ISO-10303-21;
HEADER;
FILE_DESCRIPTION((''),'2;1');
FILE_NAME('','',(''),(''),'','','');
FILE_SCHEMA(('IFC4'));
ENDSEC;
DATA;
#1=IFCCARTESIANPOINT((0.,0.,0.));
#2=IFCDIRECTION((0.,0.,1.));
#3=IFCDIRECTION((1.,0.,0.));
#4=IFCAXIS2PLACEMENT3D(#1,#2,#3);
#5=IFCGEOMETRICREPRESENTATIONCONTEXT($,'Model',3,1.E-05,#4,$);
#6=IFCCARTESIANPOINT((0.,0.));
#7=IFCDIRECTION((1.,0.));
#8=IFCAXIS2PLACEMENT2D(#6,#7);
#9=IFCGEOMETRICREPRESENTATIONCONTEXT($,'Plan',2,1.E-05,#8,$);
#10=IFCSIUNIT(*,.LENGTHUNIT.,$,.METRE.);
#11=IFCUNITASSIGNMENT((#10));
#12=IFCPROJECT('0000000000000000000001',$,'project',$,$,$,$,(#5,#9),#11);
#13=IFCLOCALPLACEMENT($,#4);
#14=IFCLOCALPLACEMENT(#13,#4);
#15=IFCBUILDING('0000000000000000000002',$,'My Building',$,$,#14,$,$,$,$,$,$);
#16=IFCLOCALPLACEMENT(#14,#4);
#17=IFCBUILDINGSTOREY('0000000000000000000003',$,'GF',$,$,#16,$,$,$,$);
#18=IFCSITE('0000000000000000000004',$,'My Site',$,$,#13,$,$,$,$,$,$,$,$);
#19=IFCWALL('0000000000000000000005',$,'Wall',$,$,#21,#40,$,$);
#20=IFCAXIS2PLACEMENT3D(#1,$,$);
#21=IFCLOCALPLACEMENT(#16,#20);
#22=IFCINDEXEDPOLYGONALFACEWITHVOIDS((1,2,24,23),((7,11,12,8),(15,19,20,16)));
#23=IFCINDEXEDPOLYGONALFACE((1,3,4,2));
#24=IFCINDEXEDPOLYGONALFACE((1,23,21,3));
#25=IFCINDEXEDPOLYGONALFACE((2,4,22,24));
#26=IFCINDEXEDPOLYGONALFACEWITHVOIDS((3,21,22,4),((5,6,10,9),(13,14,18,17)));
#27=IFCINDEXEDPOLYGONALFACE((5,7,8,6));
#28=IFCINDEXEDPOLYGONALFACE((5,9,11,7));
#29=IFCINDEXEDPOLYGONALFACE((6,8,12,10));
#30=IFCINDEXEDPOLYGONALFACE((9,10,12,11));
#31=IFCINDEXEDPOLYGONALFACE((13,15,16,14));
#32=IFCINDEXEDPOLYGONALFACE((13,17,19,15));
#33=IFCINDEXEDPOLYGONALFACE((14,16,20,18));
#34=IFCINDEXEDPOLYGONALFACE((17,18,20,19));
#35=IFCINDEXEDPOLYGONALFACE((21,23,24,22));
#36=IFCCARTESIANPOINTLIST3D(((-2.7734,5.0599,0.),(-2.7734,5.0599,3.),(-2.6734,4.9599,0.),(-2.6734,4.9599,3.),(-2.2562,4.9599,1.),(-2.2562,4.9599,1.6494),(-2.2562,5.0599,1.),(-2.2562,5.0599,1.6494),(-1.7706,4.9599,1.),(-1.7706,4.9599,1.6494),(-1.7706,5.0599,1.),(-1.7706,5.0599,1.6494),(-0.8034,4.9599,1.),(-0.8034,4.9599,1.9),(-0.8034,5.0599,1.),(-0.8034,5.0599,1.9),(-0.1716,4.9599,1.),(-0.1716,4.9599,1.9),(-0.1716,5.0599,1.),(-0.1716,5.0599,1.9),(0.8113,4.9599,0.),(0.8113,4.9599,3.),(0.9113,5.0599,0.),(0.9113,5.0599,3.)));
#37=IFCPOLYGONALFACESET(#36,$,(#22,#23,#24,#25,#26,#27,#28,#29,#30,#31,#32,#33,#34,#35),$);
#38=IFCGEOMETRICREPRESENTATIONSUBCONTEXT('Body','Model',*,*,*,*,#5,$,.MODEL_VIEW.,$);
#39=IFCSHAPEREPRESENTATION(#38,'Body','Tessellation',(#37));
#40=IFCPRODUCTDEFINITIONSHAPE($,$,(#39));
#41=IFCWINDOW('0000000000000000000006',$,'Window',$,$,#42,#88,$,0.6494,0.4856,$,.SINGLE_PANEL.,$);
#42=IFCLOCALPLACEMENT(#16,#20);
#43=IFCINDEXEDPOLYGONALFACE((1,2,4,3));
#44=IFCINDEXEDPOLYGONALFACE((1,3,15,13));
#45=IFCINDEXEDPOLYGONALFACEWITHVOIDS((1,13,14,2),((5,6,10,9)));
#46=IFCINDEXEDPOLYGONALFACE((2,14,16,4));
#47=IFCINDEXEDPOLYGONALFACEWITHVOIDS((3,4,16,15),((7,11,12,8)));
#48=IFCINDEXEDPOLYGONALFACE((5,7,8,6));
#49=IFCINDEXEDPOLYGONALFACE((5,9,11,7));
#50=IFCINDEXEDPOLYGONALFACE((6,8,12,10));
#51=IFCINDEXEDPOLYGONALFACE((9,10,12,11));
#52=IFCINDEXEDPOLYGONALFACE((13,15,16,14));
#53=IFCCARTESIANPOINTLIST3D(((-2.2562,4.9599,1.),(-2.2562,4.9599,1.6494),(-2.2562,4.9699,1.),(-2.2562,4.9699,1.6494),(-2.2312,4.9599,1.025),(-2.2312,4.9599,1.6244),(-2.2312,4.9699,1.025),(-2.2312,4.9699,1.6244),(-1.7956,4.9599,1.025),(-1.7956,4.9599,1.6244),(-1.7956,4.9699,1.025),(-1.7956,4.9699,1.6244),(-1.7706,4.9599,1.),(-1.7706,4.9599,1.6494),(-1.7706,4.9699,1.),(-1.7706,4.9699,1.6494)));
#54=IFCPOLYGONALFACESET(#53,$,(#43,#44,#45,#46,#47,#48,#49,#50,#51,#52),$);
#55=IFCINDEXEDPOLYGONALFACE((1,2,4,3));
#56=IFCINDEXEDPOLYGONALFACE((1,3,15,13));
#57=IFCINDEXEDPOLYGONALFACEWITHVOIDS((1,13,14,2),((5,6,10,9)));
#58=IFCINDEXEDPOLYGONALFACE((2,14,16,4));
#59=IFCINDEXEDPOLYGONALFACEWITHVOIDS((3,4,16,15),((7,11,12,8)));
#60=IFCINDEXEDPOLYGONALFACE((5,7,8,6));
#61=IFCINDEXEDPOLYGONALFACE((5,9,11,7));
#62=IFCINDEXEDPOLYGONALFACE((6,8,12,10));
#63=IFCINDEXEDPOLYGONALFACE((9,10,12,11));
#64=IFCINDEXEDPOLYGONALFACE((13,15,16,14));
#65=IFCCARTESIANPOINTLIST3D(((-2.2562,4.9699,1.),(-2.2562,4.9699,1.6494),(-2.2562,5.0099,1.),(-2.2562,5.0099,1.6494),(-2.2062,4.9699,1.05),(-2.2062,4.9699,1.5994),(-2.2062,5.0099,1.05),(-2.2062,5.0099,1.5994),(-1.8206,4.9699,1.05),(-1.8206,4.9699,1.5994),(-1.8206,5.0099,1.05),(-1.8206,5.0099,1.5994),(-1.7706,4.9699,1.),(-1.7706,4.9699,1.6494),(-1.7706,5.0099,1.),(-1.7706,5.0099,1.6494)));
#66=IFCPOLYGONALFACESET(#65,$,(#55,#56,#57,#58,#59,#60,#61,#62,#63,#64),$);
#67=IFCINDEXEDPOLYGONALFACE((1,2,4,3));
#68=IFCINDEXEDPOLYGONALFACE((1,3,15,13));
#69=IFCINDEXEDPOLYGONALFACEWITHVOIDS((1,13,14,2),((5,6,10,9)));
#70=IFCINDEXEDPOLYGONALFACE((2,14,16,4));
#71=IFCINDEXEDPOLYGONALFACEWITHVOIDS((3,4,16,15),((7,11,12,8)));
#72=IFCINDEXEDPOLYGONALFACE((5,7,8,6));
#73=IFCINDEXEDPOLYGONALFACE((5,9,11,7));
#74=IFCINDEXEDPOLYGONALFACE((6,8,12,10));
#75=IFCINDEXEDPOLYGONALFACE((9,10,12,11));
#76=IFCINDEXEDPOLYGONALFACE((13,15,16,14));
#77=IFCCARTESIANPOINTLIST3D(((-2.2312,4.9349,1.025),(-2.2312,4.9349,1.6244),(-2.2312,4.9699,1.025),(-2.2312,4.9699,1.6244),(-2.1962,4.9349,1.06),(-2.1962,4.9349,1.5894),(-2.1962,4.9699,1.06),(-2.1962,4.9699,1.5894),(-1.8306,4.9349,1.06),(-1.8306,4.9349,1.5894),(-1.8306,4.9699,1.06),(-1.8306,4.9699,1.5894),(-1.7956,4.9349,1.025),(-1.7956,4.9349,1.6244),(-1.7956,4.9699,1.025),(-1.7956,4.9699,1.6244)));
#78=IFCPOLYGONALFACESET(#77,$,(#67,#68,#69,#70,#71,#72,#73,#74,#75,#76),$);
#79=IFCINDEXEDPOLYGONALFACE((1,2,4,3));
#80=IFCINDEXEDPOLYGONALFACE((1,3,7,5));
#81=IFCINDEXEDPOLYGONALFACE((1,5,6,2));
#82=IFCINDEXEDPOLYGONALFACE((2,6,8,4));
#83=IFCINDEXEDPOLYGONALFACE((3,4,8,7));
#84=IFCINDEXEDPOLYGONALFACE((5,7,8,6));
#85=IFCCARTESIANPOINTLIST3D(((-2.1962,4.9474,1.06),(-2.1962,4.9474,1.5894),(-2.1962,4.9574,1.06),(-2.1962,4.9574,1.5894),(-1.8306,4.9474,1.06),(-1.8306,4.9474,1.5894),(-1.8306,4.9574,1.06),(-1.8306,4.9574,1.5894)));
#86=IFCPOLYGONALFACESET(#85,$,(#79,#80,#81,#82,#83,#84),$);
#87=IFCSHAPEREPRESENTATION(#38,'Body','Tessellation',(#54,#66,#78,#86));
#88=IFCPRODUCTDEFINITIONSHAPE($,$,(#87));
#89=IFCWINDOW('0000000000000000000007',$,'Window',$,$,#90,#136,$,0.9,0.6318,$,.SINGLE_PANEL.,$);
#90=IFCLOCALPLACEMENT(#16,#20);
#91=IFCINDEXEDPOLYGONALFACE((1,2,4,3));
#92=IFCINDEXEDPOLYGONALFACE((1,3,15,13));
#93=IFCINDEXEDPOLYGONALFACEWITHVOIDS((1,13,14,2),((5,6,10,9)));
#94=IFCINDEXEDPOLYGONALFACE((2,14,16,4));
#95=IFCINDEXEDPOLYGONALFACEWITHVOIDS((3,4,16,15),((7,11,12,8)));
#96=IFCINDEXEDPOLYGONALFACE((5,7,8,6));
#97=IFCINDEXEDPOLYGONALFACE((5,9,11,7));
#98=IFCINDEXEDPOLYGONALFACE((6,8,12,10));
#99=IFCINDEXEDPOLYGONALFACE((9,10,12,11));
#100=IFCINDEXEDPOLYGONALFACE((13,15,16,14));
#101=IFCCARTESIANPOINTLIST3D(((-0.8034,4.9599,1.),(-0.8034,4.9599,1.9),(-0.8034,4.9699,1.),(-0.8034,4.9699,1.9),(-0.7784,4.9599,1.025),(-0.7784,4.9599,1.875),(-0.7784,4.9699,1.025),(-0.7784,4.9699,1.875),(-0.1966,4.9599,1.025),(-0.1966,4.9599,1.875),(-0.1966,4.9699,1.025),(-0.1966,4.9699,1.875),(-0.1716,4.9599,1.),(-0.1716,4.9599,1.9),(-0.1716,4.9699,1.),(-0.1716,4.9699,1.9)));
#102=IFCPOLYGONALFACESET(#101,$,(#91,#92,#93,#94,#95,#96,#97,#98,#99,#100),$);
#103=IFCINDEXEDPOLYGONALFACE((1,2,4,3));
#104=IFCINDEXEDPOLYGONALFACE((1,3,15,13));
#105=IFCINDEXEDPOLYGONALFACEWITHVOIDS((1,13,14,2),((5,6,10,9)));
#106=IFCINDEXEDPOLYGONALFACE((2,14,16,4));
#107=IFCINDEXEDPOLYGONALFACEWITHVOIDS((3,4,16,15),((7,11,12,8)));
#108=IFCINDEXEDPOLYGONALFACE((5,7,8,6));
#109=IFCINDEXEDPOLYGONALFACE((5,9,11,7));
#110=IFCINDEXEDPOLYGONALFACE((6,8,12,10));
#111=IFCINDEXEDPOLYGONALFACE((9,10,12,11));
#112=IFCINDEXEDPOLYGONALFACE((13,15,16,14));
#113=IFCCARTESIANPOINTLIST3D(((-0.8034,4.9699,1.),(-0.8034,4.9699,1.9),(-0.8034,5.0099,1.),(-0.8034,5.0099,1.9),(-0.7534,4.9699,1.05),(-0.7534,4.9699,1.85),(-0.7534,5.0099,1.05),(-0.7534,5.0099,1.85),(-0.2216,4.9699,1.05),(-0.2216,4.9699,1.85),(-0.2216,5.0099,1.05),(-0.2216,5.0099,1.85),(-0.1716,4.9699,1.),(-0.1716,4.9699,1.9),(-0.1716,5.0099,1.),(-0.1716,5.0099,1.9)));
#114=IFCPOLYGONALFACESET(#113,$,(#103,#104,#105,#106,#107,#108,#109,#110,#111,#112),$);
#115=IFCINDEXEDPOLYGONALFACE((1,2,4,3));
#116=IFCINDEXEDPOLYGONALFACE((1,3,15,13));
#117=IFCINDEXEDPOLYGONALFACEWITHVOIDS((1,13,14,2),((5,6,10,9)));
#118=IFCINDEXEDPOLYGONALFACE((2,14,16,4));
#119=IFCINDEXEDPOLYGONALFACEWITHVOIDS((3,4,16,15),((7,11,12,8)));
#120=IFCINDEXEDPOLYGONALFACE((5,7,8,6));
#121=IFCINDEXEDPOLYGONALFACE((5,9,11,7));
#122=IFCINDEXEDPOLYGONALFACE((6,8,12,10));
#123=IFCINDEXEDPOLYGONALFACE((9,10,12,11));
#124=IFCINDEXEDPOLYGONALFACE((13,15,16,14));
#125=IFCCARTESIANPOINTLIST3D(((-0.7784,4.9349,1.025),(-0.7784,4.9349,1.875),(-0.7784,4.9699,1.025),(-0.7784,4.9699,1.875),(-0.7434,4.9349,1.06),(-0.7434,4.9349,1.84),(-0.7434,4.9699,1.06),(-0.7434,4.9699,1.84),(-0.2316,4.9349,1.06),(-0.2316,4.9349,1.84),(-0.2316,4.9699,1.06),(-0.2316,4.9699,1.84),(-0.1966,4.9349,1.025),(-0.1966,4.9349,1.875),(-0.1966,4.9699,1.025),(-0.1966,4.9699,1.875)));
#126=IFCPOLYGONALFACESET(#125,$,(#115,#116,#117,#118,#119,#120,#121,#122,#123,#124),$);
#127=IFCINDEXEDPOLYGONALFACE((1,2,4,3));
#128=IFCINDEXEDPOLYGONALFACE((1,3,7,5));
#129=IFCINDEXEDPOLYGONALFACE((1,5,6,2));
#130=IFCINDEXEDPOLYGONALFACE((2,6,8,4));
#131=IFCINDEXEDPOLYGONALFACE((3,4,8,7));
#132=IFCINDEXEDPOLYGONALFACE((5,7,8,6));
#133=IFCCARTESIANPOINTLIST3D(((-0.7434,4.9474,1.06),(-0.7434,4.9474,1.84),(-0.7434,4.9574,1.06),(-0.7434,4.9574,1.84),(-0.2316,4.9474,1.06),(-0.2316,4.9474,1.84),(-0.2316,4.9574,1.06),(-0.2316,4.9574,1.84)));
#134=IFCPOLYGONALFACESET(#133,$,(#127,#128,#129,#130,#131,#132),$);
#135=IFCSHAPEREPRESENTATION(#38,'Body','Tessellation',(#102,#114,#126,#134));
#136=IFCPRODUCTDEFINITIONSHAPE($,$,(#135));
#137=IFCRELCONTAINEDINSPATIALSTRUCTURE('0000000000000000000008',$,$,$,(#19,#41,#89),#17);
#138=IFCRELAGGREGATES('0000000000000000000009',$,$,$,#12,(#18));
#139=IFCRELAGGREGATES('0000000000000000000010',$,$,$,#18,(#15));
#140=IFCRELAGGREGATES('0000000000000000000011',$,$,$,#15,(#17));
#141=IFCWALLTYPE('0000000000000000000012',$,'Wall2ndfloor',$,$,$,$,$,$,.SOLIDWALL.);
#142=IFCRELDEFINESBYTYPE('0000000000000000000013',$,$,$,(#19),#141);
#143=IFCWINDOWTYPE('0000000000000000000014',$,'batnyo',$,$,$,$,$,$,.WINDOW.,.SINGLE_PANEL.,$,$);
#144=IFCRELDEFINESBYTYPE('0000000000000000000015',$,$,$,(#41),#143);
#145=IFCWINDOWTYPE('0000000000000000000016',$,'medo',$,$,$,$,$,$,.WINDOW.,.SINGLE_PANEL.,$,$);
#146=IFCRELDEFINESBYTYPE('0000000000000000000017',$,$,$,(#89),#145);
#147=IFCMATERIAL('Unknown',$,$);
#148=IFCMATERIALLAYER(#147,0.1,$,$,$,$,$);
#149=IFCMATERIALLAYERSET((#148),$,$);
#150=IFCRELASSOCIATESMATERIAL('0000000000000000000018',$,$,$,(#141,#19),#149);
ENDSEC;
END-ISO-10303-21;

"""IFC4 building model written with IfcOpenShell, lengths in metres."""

from ifc_helpers import new_model, entity, si_unit, frame, origin_with_axes, origin_2d_with_axis, place, context, subcontext, project, spatial, line, indexed_curve, outline, extrude, shape, source, transform, mapped, material, layer, layer_set, layer_usage, type_object, type_shapes, element, fill, save


model = new_model("IFC4")

# Units and contexts
model_context = context("Model", 3, precision=1e-05, world=origin_with_axes())
plan_context = context("Plan", 2, precision=1e-05, world=origin_2d_with_axis())
body_context_1 = subcontext(model_context, "Body", "Model", "MODEL_VIEW")
body_context_2 = subcontext(plan_context, "Body", "Plan", "PLAN_VIEW")
ifc_project = project(units=[si_unit("LENGTHUNIT", "METRE")], contexts=[model_context, plan_context])

# Site, building, storey
site_placement = place(None, origin_with_axes())
site = spatial("IfcSite", under=ifc_project, at=site_placement, Name="My Site")
building_placement = place(site_placement, origin_with_axes())
building = spatial("IfcBuilding", under=site, at=building_placement, Name="My Building")
storey_placement = place(building_placement, origin_with_axes())
storey = spatial("IfcBuildingStorey", under=building, at=storey_placement, Name="GF")

# Shared definitions
ifc_material = material(Name="Unknown")

# Shared definitions
ifc_layer_1 = layer(ifc_material, 0.1)
ifc_layer_set_1 = layer_set([ifc_layer_1])
wall_type_1 = type_object("IfcWallType", Name="Wall2ndfloor", PredefinedType="SOLIDWALL", material=ifc_layer_set_1)

# Wall, openings, windows
ifc_layer_usage_1 = layer_usage(ifc_layer_set_1, "AXIS2", "POSITIVE", 0.0)
wall_1_placement = place(storey_placement, frame((0.9113, 5.0599, 0.0), z_axis=(0.0, 0.0, 1.0), x_axis=(-1.0, 0.0, 0.0)))
wall_1 = element("IfcWall", 1, at=wall_1_placement, inside=storey, type_object=wall_type_1, material=ifc_layer_usage_1, Name="Wall", context=body_context_1, shape_type="SweptSolid", body=[
    extrude(outline(indexed_curve([(0.0, 0.0), (0.1, 0.1), (3.5847, 0.1), (3.6847, 0.0)], segments=[line(1, 2, 3, 4, 1)])), origin_with_axes(), (0.0, 0.0, 1.0), 3.0),
])
shared_shape_1 = source(origin_with_axes(), body_context_1, "Body", "SweptSolid", [
    extrude(outline(indexed_curve([(0.0, 0.0), (0.4856, 0.0), (0.4856, 0.6494), (0.0, 0.6494)], segments=[line(1, 2, 3, 4, 1)])), frame((0.0, -0.6, 0.0), z_axis=(0.0, -1.0, 0.0), x_axis=(1.0, 0.0, 0.0)), (0.0, 0.0, -1.0), 1.2),
])
opening_1_placement = place(wall_1_placement, frame((2.6819, 0.0, 1.0), z_axis=(0.0, 0.0, 1.0), x_axis=(1.0, 0.0, 0.0)))
opening_1 = element("IfcOpeningElement", 2, at=opening_1_placement, cuts=wall_1, PredefinedType="OPENING", context=body_context_1, shape_type="MappedRepresentation", body=[
    mapped(shared_shape_1, transform((0.0, 0.0, 0.0), x_axis=(1.0, 0.0, 0.0), y_axis=(0.0, 1.0, 0.0), z_axis=(0.0, 0.0, 1.0), scale=1.0)),
])
shared_shape_2 = source(origin_with_axes(), body_context_1, "Body", "SweptSolid", [
    extrude(outline(indexed_curve([(0.0, 0.0), (0.6318, 0.0), (0.6318, 0.9), (0.0, 0.9)], segments=[line(1, 2, 3, 4, 1)])), frame((0.0, -0.6, 0.0), z_axis=(0.0, -1.0, 0.0), x_axis=(1.0, 0.0, 0.0)), (0.0, 0.0, -1.0), 1.2),
])
opening_2_placement = place(wall_1_placement, frame((1.083, 0.0, 1.0), z_axis=(0.0, 0.0, 1.0), x_axis=(1.0, 0.0, 0.0)))
opening_2 = element("IfcOpeningElement", 3, at=opening_2_placement, cuts=wall_1, PredefinedType="OPENING", context=body_context_1, shape_type="MappedRepresentation", body=[
    mapped(shared_shape_2, transform((0.0, 0.0, 0.0), x_axis=(1.0, 0.0, 0.0), y_axis=(0.0, 1.0, 0.0), z_axis=(0.0, 0.0, 1.0), scale=1.0)),
])
window_type_1 = type_object("IfcWindowType", Name="batnyo", PartitioningType="SINGLE_PANEL", PredefinedType="WINDOW")
shared_shape_3 = source(origin_with_axes(), body_context_1, "Body", "SweptSolid", [
    extrude(outline(indexed_curve([(0.0, 0.0), (0.4856, 0.0), (0.4856, 0.6494), (0.0, 0.6494)], segments=[line(1, 2, 3, 4, 1)]), holes=[indexed_curve([(0.025, 0.025), (0.4606, 0.025), (0.4606, 0.6244), (0.025, 0.6244)], segments=[line(1, 2, 3, 4, 1)])]), frame((0.0, 0.09, 0.0), z_axis=(0.0, -1.0, 0.0), x_axis=(1.0, 0.0, 0.0)), (0.0, 0.0, -1.0), 0.01),
    extrude(outline(indexed_curve([(0.0, 0.0), (0.4856, 0.0), (0.4856, 0.6494), (0.0, 0.6494)], segments=[line(1, 2, 3, 4, 1)]), holes=[indexed_curve([(0.05, 0.05), (0.4356, 0.05), (0.4356, 0.5994), (0.05, 0.5994)], segments=[line(1, 2, 3, 4, 1)])]), frame((0.0, 0.05, 0.0), z_axis=(0.0, -1.0, 0.0), x_axis=(1.0, 0.0, 0.0)), (0.0, 0.0, -1.0), 0.04),
    extrude(outline(indexed_curve([(0.0, 0.0), (0.4356, 0.0), (0.4356, 0.5994), (0.0, 0.5994)], segments=[line(1, 2, 3, 4, 1)]), holes=[indexed_curve([(0.035, 0.035), (0.4006, 0.035), (0.4006, 0.5644), (0.035, 0.5644)], segments=[line(1, 2, 3, 4, 1)])]), frame((0.025, 0.09, 0.025), z_axis=(0.0, -1.0, 0.0), x_axis=(1.0, 0.0, 0.0)), (0.0, 0.0, -1.0), 0.035),
    extrude(outline(indexed_curve([(0.035, 0.035), (0.4006, 0.035), (0.4006, 0.5644), (0.035, 0.5644)], segments=[line(1, 2, 3, 4, 1)])), frame((0.025, 0.1025, 0.025), z_axis=(0.0, -1.0, 0.0), x_axis=(1.0, 0.0, 0.0)), (0.0, 0.0, -1.0), 0.01),
])
shared_shape_4 = source(origin_with_axes(), body_context_2, "Body", "Curve2D", [
    entity("IfcIndexedPolyCurve", entity("IfcCartesianPointList2D", [[0.05, 0.05], [0.4356, 0.05]])),
    entity("IfcIndexedPolyCurve", entity("IfcCartesianPointList2D", [[0.0, 0.1], [0.025, 0.1], [0.025, 0.09], [0.05, 0.09], [0.05, 0.05], [0.0, 0.05]]), [entity("IfcLineIndex", [1, 2, 3, 4, 5, 6, 1])]),
    entity("IfcIndexedPolyCurve", entity("IfcCartesianPointList2D", [[0.4856, 0.1], [0.4606, 0.1], [0.4606, 0.09], [0.4356, 0.09], [0.4356, 0.05], [0.4856, 0.05]]), [entity("IfcLineIndex", [1, 2, 3, 4, 5, 6, 1])]),
    entity("IfcIndexedPolyCurve", entity("IfcCartesianPointList2D", [[0.025, 0.09], [0.06, 0.09], [0.06, 0.125], [0.025, 0.125]]), [entity("IfcLineIndex", [1, 2, 3, 4, 1])]),
    entity("IfcIndexedPolyCurve", entity("IfcCartesianPointList2D", [[0.4606, 0.09], [0.4256, 0.09], [0.4256, 0.125], [0.4606, 0.125]]), [entity("IfcLineIndex", [1, 2, 3, 4, 1])]),
    entity("IfcIndexedPolyCurve", entity("IfcCartesianPointList2D", [[0.06, 0.09], [0.4256, 0.09]])),
    entity("IfcIndexedPolyCurve", entity("IfcCartesianPointList2D", [[0.06, 0.125], [0.4256, 0.125]])),
    entity("IfcIndexedPolyCurve", entity("IfcCartesianPointList2D", [[0.06, 0.1075], [0.4256, 0.1075]])),
])
type_shapes(window_type_1, [shared_shape_3, shared_shape_4])
window_1_placement = place(opening_1_placement, frame((0.0, 0.0, 0.0), z_axis=(0.0, 0.0, 1.0), x_axis=(1.0, 0.0, 0.0)))
window_1 = element("IfcWindow", 4, at=window_1_placement, inside=storey, type_object=window_type_1, Name="Window", OverallHeight=0.6494, OverallWidth=0.4856, PartitioningType="SINGLE_PANEL", shapes=[
    shape(body_context_1, "Body", "MappedRepresentation", [mapped(shared_shape_3, transform((0.0, 0.0, 0.0), x_axis=(1.0, 0.0, 0.0), y_axis=(0.0, 1.0, 0.0), z_axis=(0.0, 0.0, 1.0), scale=1.0))]),
    shape(body_context_2, "Body", "MappedRepresentation", [mapped(shared_shape_4, transform((0.0, 0.0, 0.0), x_axis=(1.0, 0.0, 0.0), y_axis=(0.0, 1.0, 0.0), z_axis=(0.0, 0.0, 1.0), scale=1.0))]),
])
fill(opening_1, window_1)
window_type_2 = type_object("IfcWindowType", Name="medo", PartitioningType="SINGLE_PANEL", PredefinedType="WINDOW")
shared_shape_5 = source(origin_with_axes(), body_context_1, "Body", "SweptSolid", [
    extrude(outline(indexed_curve([(0.0, 0.0), (0.6318, 0.0), (0.6318, 0.9), (0.0, 0.9)], segments=[line(1, 2, 3, 4, 1)]), holes=[indexed_curve([(0.025, 0.025), (0.6068, 0.025), (0.6068, 0.875), (0.025, 0.875)], segments=[line(1, 2, 3, 4, 1)])]), frame((0.0, 0.09, 0.0), z_axis=(0.0, -1.0, 0.0), x_axis=(1.0, 0.0, 0.0)), (0.0, 0.0, -1.0), 0.01),
    extrude(outline(indexed_curve([(0.0, 0.0), (0.6318, 0.0), (0.6318, 0.9), (0.0, 0.9)], segments=[line(1, 2, 3, 4, 1)]), holes=[indexed_curve([(0.05, 0.05), (0.5818, 0.05), (0.5818, 0.85), (0.05, 0.85)], segments=[line(1, 2, 3, 4, 1)])]), frame((0.0, 0.05, 0.0), z_axis=(0.0, -1.0, 0.0), x_axis=(1.0, 0.0, 0.0)), (0.0, 0.0, -1.0), 0.04),
    extrude(outline(indexed_curve([(0.0, 0.0), (0.5818, 0.0), (0.5818, 0.85), (0.0, 0.85)], segments=[line(1, 2, 3, 4, 1)]), holes=[indexed_curve([(0.035, 0.035), (0.5468, 0.035), (0.5468, 0.815), (0.035, 0.815)], segments=[line(1, 2, 3, 4, 1)])]), frame((0.025, 0.09, 0.025), z_axis=(0.0, -1.0, 0.0), x_axis=(1.0, 0.0, 0.0)), (0.0, 0.0, -1.0), 0.035),
    extrude(outline(indexed_curve([(0.035, 0.035), (0.5468, 0.035), (0.5468, 0.815), (0.035, 0.815)], segments=[line(1, 2, 3, 4, 1)])), frame((0.025, 0.1025, 0.025), z_axis=(0.0, -1.0, 0.0), x_axis=(1.0, 0.0, 0.0)), (0.0, 0.0, -1.0), 0.01),
])
shared_shape_6 = source(origin_with_axes(), body_context_2, "Body", "Curve2D", [
    entity("IfcIndexedPolyCurve", entity("IfcCartesianPointList2D", [[0.05, 0.05], [0.5818, 0.05]])),
    entity("IfcIndexedPolyCurve", entity("IfcCartesianPointList2D", [[0.0, 0.1], [0.025, 0.1], [0.025, 0.09], [0.05, 0.09], [0.05, 0.05], [0.0, 0.05]]), [entity("IfcLineIndex", [1, 2, 3, 4, 5, 6, 1])]),
    entity("IfcIndexedPolyCurve", entity("IfcCartesianPointList2D", [[0.6318, 0.1], [0.6068, 0.1], [0.6068, 0.09], [0.5818, 0.09], [0.5818, 0.05], [0.6318, 0.05]]), [entity("IfcLineIndex", [1, 2, 3, 4, 5, 6, 1])]),
    entity("IfcIndexedPolyCurve", entity("IfcCartesianPointList2D", [[0.025, 0.09], [0.06, 0.09], [0.06, 0.125], [0.025, 0.125]]), [entity("IfcLineIndex", [1, 2, 3, 4, 1])]),
    entity("IfcIndexedPolyCurve", entity("IfcCartesianPointList2D", [[0.6068, 0.09], [0.5718, 0.09], [0.5718, 0.125], [0.6068, 0.125]]), [entity("IfcLineIndex", [1, 2, 3, 4, 1])]),
    entity("IfcIndexedPolyCurve", entity("IfcCartesianPointList2D", [[0.06, 0.09], [0.5718, 0.09]])),
    entity("IfcIndexedPolyCurve", entity("IfcCartesianPointList2D", [[0.06, 0.125], [0.5718, 0.125]])),
    entity("IfcIndexedPolyCurve", entity("IfcCartesianPointList2D", [[0.06, 0.1075], [0.5718, 0.1075]])),
])
type_shapes(window_type_2, [shared_shape_5, shared_shape_6])
window_2_placement = place(opening_2_placement, frame((0.0, 0.0, 0.0), z_axis=(0.0, 0.0, 1.0), x_axis=(1.0, 0.0, 0.0)))
window_2 = element("IfcWindow", 5, at=window_2_placement, inside=storey, type_object=window_type_2, Name="Window", OverallHeight=0.9, OverallWidth=0.6318, PartitioningType="SINGLE_PANEL", shapes=[
    shape(body_context_1, "Body", "MappedRepresentation", [mapped(shared_shape_5, transform((0.0, 0.0, 0.0), x_axis=(1.0, 0.0, 0.0), y_axis=(0.0, 1.0, 0.0), z_axis=(0.0, 0.0, 1.0), scale=1.0))]),
    shape(body_context_2, "Body", "MappedRepresentation", [mapped(shared_shape_6, transform((0.0, 0.0, 0.0), x_axis=(1.0, 0.0, 0.0), y_axis=(0.0, 1.0, 0.0), z_axis=(0.0, 0.0, 1.0), scale=1.0))]),
])
fill(opening_2, window_2)

save(model, "model.ifc")
